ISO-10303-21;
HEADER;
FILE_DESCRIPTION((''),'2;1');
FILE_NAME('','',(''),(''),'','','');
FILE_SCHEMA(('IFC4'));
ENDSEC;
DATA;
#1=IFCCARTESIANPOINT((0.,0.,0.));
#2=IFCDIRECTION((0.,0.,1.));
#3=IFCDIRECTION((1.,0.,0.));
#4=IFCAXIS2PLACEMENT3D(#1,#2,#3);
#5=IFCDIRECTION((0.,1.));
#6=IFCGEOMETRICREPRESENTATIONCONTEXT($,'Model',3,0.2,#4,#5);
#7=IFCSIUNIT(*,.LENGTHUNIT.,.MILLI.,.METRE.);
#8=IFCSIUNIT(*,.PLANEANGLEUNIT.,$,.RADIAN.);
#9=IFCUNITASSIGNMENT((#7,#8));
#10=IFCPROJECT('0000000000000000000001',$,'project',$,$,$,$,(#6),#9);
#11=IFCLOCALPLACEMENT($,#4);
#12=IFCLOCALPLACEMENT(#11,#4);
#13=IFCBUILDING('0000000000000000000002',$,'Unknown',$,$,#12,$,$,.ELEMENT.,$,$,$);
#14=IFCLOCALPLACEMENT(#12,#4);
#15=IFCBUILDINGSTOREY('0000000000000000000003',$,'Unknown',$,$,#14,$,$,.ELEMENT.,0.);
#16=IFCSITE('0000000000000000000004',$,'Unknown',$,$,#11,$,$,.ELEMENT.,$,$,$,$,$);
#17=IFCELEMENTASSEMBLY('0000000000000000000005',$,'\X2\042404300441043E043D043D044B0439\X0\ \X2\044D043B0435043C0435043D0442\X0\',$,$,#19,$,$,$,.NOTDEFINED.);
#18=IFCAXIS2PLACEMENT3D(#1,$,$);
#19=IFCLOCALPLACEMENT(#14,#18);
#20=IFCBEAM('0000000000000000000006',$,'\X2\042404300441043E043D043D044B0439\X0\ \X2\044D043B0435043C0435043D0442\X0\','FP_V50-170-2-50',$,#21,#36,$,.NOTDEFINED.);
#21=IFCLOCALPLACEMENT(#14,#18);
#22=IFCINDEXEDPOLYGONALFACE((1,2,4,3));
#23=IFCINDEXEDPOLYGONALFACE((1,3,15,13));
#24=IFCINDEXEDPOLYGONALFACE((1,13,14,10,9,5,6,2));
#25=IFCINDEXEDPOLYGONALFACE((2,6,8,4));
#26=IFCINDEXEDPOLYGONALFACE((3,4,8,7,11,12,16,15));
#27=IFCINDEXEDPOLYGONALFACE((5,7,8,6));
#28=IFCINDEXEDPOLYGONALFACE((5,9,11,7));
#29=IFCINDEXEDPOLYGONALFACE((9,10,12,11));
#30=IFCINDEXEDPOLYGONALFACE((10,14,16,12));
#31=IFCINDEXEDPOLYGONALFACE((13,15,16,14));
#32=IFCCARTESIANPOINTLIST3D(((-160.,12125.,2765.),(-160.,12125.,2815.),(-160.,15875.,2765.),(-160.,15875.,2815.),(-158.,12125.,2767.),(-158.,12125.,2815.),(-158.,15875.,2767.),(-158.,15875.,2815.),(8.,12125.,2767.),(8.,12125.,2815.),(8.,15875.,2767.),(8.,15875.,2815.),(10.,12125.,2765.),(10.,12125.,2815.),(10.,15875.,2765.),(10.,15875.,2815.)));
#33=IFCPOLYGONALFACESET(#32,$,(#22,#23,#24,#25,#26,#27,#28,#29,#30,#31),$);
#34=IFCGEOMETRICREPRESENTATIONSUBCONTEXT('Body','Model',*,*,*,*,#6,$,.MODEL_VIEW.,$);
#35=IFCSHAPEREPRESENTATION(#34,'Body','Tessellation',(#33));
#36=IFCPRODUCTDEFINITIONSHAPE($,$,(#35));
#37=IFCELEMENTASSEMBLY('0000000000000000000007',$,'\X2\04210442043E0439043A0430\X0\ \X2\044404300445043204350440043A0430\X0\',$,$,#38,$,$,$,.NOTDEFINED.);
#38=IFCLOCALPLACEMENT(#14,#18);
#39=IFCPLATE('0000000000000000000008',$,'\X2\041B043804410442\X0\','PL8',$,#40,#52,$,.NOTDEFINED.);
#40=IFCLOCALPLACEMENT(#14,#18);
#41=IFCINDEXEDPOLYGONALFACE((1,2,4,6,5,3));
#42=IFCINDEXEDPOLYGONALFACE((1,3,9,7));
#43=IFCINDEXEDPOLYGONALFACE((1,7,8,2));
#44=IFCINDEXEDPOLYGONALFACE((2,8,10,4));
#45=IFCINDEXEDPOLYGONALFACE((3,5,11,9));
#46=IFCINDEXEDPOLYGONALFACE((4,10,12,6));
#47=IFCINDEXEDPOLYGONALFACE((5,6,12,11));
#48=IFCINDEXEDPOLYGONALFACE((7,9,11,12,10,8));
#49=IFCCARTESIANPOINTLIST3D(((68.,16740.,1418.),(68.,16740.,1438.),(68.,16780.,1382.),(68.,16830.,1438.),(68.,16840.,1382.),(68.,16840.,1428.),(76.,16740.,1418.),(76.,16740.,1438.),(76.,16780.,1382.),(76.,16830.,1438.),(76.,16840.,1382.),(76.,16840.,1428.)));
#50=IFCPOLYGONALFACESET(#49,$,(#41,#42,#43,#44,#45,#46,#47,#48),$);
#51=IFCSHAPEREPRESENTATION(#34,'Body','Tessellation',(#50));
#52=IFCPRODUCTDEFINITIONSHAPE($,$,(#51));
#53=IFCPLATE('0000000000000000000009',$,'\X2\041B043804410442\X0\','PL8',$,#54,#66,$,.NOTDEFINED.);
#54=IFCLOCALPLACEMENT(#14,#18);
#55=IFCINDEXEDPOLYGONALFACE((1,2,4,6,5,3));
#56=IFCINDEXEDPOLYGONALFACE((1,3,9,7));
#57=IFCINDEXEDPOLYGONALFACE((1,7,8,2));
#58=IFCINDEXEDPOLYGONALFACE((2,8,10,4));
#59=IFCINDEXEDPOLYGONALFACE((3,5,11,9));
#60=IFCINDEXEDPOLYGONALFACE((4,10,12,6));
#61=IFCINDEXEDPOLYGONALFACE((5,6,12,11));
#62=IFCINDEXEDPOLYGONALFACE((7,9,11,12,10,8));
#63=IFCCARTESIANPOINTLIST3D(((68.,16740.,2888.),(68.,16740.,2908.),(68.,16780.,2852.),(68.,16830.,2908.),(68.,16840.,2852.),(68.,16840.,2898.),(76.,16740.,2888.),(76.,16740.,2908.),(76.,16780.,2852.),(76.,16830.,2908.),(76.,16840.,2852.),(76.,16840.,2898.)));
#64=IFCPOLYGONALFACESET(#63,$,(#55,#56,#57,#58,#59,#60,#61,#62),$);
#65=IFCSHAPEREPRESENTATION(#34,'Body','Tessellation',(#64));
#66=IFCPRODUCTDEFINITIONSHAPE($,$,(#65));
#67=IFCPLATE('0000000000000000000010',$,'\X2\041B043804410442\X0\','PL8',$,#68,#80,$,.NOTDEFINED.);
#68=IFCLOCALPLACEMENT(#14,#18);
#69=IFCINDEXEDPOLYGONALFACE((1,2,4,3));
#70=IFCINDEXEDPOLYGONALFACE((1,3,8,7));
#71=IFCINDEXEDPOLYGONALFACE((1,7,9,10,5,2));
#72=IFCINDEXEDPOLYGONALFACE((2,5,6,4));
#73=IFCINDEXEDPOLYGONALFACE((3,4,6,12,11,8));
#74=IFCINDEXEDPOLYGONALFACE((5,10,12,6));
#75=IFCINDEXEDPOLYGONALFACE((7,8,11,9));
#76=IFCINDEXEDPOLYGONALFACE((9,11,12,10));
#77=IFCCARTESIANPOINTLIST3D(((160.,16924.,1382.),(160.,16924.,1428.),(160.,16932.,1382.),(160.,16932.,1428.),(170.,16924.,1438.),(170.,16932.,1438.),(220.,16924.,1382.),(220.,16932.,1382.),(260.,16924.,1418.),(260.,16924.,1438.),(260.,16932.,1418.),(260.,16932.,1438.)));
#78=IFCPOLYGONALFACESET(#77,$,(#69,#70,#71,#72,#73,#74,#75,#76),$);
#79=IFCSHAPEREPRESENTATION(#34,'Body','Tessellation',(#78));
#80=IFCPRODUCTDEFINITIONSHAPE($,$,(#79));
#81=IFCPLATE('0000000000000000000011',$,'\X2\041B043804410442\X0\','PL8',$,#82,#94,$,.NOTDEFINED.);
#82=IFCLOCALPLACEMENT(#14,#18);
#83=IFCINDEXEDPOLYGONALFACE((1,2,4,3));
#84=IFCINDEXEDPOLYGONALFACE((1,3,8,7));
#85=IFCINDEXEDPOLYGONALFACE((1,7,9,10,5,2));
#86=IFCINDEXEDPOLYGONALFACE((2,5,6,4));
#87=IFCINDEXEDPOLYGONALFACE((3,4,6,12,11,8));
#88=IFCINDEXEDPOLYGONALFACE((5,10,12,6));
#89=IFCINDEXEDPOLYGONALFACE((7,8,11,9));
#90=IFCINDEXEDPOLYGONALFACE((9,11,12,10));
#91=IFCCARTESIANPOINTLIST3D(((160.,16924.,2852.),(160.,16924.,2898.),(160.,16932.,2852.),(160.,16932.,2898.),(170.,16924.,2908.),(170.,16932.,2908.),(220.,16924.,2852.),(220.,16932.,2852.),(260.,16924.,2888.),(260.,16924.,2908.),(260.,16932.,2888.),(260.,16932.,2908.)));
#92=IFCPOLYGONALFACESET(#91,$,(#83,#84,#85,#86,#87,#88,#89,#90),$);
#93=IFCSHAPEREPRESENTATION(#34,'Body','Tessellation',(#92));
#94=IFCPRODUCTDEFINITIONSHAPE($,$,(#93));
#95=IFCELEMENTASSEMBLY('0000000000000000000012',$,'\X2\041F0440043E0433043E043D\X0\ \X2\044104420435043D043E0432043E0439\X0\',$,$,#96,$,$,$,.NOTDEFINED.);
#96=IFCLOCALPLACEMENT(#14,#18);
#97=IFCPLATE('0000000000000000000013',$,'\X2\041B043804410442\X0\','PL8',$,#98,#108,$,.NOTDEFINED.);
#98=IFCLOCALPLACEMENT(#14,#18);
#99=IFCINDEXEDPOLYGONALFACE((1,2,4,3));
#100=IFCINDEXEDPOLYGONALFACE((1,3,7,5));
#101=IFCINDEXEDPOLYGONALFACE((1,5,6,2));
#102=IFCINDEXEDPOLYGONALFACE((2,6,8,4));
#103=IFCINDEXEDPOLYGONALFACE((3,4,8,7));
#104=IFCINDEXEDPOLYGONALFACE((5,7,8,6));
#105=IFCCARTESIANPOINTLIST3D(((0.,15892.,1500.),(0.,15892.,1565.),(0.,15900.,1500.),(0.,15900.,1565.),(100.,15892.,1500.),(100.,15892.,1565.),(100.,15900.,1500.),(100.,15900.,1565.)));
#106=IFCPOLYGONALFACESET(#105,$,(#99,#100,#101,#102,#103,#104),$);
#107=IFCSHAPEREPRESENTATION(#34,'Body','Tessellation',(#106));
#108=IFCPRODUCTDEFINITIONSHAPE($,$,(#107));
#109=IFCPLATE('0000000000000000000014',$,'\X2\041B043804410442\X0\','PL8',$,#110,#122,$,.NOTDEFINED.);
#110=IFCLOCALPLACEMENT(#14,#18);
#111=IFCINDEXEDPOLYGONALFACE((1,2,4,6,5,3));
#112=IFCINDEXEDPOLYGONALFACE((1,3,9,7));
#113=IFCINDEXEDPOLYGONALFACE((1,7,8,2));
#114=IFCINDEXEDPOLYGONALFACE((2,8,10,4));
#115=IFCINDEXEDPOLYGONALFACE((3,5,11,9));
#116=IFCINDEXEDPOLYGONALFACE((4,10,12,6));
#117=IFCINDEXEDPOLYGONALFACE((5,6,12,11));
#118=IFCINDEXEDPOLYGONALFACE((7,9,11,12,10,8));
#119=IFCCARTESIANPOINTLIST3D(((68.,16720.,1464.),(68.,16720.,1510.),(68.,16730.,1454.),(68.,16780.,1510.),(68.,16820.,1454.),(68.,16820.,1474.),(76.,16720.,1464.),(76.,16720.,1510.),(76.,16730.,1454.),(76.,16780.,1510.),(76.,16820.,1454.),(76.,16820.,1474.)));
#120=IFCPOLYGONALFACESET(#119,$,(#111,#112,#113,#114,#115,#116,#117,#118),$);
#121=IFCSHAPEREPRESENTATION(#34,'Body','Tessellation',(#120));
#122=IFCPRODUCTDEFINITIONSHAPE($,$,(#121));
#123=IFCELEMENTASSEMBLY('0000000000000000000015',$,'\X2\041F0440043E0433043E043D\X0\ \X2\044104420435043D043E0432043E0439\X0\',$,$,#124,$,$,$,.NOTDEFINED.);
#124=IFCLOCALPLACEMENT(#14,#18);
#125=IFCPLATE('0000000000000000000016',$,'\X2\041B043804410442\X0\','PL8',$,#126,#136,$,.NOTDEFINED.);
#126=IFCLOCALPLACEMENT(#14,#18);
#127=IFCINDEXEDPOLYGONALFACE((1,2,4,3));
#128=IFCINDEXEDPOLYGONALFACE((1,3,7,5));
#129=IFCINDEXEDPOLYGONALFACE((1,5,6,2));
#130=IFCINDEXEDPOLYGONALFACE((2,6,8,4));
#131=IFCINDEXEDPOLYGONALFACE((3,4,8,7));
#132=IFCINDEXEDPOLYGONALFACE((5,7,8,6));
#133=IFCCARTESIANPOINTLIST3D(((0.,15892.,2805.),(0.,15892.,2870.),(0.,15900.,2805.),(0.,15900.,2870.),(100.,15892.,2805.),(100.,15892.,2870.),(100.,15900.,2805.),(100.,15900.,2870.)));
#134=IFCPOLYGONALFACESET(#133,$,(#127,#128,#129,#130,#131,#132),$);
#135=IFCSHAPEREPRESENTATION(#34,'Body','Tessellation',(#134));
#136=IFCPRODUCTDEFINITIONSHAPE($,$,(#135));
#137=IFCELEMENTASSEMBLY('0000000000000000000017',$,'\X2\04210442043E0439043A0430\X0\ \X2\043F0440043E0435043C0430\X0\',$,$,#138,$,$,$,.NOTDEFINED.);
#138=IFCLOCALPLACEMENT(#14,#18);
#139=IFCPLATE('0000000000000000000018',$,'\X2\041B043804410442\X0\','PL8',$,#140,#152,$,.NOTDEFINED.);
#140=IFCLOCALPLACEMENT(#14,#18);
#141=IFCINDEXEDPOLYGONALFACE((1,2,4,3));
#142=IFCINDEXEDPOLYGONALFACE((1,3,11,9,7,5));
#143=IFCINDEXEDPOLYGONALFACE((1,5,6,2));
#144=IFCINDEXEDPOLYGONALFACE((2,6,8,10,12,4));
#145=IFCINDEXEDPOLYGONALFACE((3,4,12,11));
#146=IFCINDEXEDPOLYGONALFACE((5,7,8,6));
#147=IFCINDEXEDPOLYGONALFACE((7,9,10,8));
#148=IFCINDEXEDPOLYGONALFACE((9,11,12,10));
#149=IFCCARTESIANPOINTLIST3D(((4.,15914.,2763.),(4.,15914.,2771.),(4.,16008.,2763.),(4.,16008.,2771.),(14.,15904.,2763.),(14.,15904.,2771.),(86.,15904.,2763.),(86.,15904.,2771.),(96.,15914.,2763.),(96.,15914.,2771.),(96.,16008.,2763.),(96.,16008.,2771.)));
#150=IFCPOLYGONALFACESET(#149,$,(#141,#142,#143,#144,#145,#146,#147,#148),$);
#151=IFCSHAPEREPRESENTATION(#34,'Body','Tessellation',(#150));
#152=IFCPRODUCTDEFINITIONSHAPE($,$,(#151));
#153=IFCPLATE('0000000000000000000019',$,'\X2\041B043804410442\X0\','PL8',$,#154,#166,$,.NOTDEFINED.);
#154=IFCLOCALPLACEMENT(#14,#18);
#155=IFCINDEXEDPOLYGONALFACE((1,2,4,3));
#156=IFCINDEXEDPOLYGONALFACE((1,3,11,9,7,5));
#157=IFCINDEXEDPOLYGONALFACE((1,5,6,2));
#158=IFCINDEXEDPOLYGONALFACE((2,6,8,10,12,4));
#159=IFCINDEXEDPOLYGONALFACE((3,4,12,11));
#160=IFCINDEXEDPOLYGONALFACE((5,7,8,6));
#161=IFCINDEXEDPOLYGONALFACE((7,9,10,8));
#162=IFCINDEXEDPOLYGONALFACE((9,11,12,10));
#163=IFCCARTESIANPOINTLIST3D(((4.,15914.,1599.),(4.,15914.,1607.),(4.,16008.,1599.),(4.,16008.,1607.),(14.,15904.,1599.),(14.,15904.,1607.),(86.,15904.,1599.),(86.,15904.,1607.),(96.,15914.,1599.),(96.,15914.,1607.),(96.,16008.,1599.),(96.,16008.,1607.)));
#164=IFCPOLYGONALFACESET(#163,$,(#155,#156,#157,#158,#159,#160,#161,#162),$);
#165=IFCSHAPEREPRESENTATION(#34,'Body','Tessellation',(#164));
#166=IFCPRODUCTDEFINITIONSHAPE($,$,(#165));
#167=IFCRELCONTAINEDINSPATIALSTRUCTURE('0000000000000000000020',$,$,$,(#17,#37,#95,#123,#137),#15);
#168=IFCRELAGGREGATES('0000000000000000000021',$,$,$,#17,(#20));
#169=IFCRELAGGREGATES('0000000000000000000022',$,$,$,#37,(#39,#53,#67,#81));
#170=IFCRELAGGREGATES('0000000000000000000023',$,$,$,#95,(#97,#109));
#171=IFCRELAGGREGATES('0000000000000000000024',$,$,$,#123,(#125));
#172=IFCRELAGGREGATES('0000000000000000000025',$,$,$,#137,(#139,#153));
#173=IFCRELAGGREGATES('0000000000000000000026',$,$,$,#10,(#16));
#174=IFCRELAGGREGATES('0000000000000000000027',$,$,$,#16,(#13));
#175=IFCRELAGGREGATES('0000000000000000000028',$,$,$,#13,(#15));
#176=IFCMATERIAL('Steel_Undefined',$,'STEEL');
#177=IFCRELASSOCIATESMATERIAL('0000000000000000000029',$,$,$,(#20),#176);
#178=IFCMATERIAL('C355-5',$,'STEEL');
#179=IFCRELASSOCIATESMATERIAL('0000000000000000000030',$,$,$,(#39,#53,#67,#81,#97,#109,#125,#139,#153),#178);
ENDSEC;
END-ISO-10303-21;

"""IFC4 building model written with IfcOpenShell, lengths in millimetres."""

from ifc_helpers import new_model, si_unit, direction, frame, origin_with_axes, place, context, subcontext, project, spatial, line, indexed_curve, outline, extrude, material, element, aggregate, save


model = new_model("IFC4")

# Units and contexts
model_context = context("Model", 3, precision=0.2, world=origin_with_axes(), true_north=direction((0.0, 1.0)))
body_context = subcontext(model_context, "Body", "Model", "MODEL_VIEW")
ifc_project = project(units=[si_unit("LENGTHUNIT", "METRE", prefix="MILLI"), si_unit("PLANEANGLEUNIT", "RADIAN")], contexts=[model_context])

# Site, building, storey
site_placement = place(None, origin_with_axes())
site = spatial("IfcSite", under=ifc_project, at=site_placement, Name="Unknown", CompositionType="ELEMENT")
building_placement = place(site_placement, origin_with_axes())
building = spatial("IfcBuilding", under=site, at=building_placement, Name="Unknown", CompositionType="ELEMENT")
storey_placement = place(building_placement, origin_with_axes())
storey = spatial("IfcBuildingStorey", under=building, at=storey_placement, Name="Unknown", CompositionType="ELEMENT", Elevation=0.0)

# Element assembly, beam
ifc_material_1 = material(Name="Steel_Undefined", Category="STEEL")
assembly_1_placement = place(storey_placement, frame((-75.0, 15875.0, 2790.0), z_axis=(1.0, 0.0, 0.0), x_axis=(0.0, -1.0, 0.0)))
assembly_1 = element("IfcElementAssembly", 1, at=assembly_1_placement, inside=storey, Name="Фасонный элемент", PredefinedType="NOTDEFINED")
beam_1_placement = place(assembly_1_placement, origin_with_axes())
beam_1 = element("IfcBeam", 2, at=beam_1_placement, material=ifc_material_1, Name="Фасонный элемент", Description="FP_V50-170-2-50", PredefinedType="NOTDEFINED", context=body_context, shape_type="SolidModel", body=[
    extrude(outline(indexed_curve([(-85.0, -25.0), (-83.0, -25.0), (-83.0, 23.0), (83.0, 23.0), (83.0, -25.0), (85.0, -25.0), (85.0, 25.0), (-85.0, 25.0)], segments=[line(1, 2, 3, 4, 5, 6, 7, 8, 1)])), frame((0.0, 0.0, 0.0), z_axis=(-1.0, 0.0, 0.0), x_axis=(0.0, 0.0, 1.0)), (0.0, 0.0, -1.0), 3750.0),
])
aggregate(assembly_1, [beam_1])

# Element assemblies, plates
assembly_2_placement = place(storey_placement, frame((80.0, 16920.0, -200.0), z_axis=(0.0, -1.0, 0.0), x_axis=(0.0, 0.0, 1.0)))
assembly_2 = element("IfcElementAssembly", 3, at=assembly_2_placement, inside=storey, Name="Стойка фахверка", PredefinedType="NOTDEFINED")
ifc_material_2 = material(Name="C355-5", Category="STEEL")
plate_1_placement = place(assembly_2_placement, frame((1638.0, 8.0, 90.0), z_axis=(0.0, -1.0, 0.0), x_axis=(0.0, 0.0, 1.0)))
plate_1 = element("IfcPlate", 4, at=plate_1_placement, material=ifc_material_2, Name="Лист", Description="PL8", PredefinedType="NOTDEFINED", context=body_context, shape_type="SolidModel", body=[
    extrude(outline(indexed_curve([(0.0, 0.0), (90.0, 0.0), (90.0, 20.0), (50.0, 56.0), (-10.0, 56.0), (-10.0, 10.0)], segments=[line(1, 2, 3, 4, 5, 6, 1)])), frame((0.0, 0.0, 4.0), z_axis=(0.0, 0.0, 1.0), x_axis=(1.0, 0.0, 0.0)), (0.0, 0.0, -1.0), 8.0),
])
plate_2_placement = place(assembly_2_placement, frame((3108.0, 8.0, 90.0), z_axis=(0.0, -1.0, 0.0), x_axis=(0.0, 0.0, 1.0)))
plate_2 = element("IfcPlate", 5, at=plate_2_placement, material=ifc_material_2, Name="Лист", Description="PL8", PredefinedType="NOTDEFINED", context=body_context, shape_type="SolidModel", body=[
    extrude(outline(indexed_curve([(0.0, 0.0), (90.0, 0.0), (90.0, 20.0), (50.0, 56.0), (-10.0, 56.0), (-10.0, 10.0)], segments=[line(1, 2, 3, 4, 5, 6, 1)])), frame((0.0, 0.0, 4.0), z_axis=(0.0, 0.0, 1.0), x_axis=(1.0, 0.0, 0.0)), (0.0, 0.0, -1.0), 8.0),
])
plate_3_placement = place(assembly_2_placement, frame((1638.0, -90.0, -8.0), z_axis=(0.0, 0.0, -1.0), x_axis=(0.0, -1.0, 0.0)))
plate_3 = element("IfcPlate", 6, at=plate_3_placement, material=ifc_material_2, Name="Лист", Description="PL8", PredefinedType="NOTDEFINED", context=body_context, shape_type="SolidModel", body=[
    extrude(outline(indexed_curve([(0.0, 0.0), (90.0, 0.0), (90.0, 20.0), (50.0, 56.0), (-10.0, 56.0), (-10.0, 10.0)], segments=[line(1, 2, 3, 4, 5, 6, 1)])), frame((0.0, 0.0, 4.0), z_axis=(0.0, 0.0, 1.0), x_axis=(1.0, 0.0, 0.0)), (0.0, 0.0, -1.0), 8.0),
])
plate_4_placement = place(assembly_2_placement, frame((3108.0, -90.0, -8.0), z_axis=(0.0, 0.0, -1.0), x_axis=(0.0, -1.0, 0.0)))
plate_4 = element("IfcPlate", 7, at=plate_4_placement, material=ifc_material_2, Name="Лист", Description="PL8", PredefinedType="NOTDEFINED", context=body_context, shape_type="SolidModel", body=[
    extrude(outline(indexed_curve([(0.0, 0.0), (90.0, 0.0), (90.0, 20.0), (50.0, 56.0), (-10.0, 56.0), (-10.0, 10.0)], segments=[line(1, 2, 3, 4, 5, 6, 1)])), frame((0.0, 0.0, 4.0), z_axis=(0.0, 0.0, 1.0), x_axis=(1.0, 0.0, 0.0)), (0.0, 0.0, -1.0), 8.0),
])
aggregate(assembly_2, [plate_1, plate_2, plate_3, plate_4])
assembly_3_placement = place(storey_placement, frame((50.0, 17000.0, 1450.0), z_axis=(0.0, 0.0, -1.0), x_axis=(0.0, -1.0, 0.0)))
assembly_3 = element("IfcElementAssembly", 8, at=assembly_3_placement, inside=storey, Name="Прогон стеновой", PredefinedType="NOTDEFINED")
plate_5_placement = place(assembly_3_placement, frame((1104.0, 50.0, -50.0), z_axis=(-1.0, 0.0, 0.0), x_axis=(0.0, 0.0, -1.0)))
plate_5 = element("IfcPlate", 9, at=plate_5_placement, material=ifc_material_2, Name="Лист", Description="PL8", PredefinedType="NOTDEFINED", context=body_context, shape_type="SolidModel", body=[
    extrude(outline(indexed_curve([(0.0, 0.0), (65.0, 0.0), (65.0, 100.0), (0.0, 100.0)], segments=[line(1, 2, 3, 4, 1)])), frame((0.0, 0.0, 4.0), z_axis=(0.0, 0.0, 1.0), x_axis=(1.0, 0.0, 0.0)), (0.0, 0.0, -1.0), 8.0),
])
plate_6_placement = place(assembly_3_placement, frame((180.0, -22.0, -60.0), z_axis=(0.0, 1.0, 0.0), x_axis=(0.0, 0.0, 1.0)))
plate_6 = element("IfcPlate", 10, at=plate_6_placement, material=ifc_material_2, Name="Лист", Description="PL8", PredefinedType="NOTDEFINED", context=body_context, shape_type="SolidModel", body=[
    extrude(outline(indexed_curve([(0.0, 40.0), (36.0, 0.0), (56.0, 0.0), (56.0, 90.0), (46.0, 100.0), (0.0, 100.0)], segments=[line(1, 2, 3, 4, 5, 6, 1)])), frame((0.0, 0.0, 4.0), z_axis=(0.0, 0.0, 1.0), x_axis=(1.0, 0.0, 0.0)), (0.0, 0.0, -1.0), 8.0),
])
aggregate(assembly_3, [plate_5, plate_6])
assembly_4_placement = place(storey_placement, frame((50.0, 17000.0, 2920.0), z_axis=(0.0, 0.0, -1.0), x_axis=(0.0, -1.0, 0.0)))
assembly_4 = element("IfcElementAssembly", 11, at=assembly_4_placement, inside=storey, Name="Прогон стеновой", PredefinedType="NOTDEFINED")
plate_7_placement = place(assembly_4_placement, frame((1104.0, -50.0, 50.0), z_axis=(-1.0, 0.0, 0.0), x_axis=(0.0, 0.0, 1.0)))
plate_7 = element("IfcPlate", 12, at=plate_7_placement, material=ifc_material_2, Name="Лист", Description="PL8", PredefinedType="NOTDEFINED", context=body_context, shape_type="SolidModel", body=[
    extrude(outline(indexed_curve([(0.0, 0.0), (65.0, 0.0), (65.0, 100.0), (0.0, 100.0)], segments=[line(1, 2, 3, 4, 1)])), frame((0.0, 0.0, 4.0), z_axis=(0.0, 0.0, 1.0), x_axis=(1.0, 0.0, 0.0)), (0.0, 0.0, -1.0), 8.0),
])
aggregate(assembly_4, [plate_7])
assembly_5_placement = place(storey_placement, frame((50.0, 15950.0, 1500.0), z_axis=(0.0, -1.0, 0.0), x_axis=(0.0, 0.0, 1.0)))
assembly_5 = element("IfcElementAssembly", 13, at=assembly_5_placement, inside=storey, Name="Стойка проема", PredefinedType="NOTDEFINED")
plate_8_placement = place(assembly_5_placement, frame((1267.0, 46.0, 46.0), z_axis=(1.0, 0.0, 0.0), x_axis=(0.0, -1.0, 0.0)))
plate_8 = element("IfcPlate", 14, at=plate_8_placement, material=ifc_material_2, Name="Лист", Description="PL8", PredefinedType="NOTDEFINED", context=body_context, shape_type="SolidModel", body=[
    extrude(outline(indexed_curve([(0.0, 10.0), (10.0, 0.0), (82.0, 0.0), (92.0, 10.0), (92.0, 104.0), (0.0, 104.0)], segments=[line(1, 2, 3, 4, 5, 6, 1)])), frame((0.0, 0.0, 4.0), z_axis=(0.0, 0.0, 1.0), x_axis=(1.0, 0.0, 0.0)), (0.0, 0.0, -1.0), 8.0),
])
plate_9_placement = place(assembly_5_placement, frame((103.0, -46.0, 46.0), z_axis=(-1.0, 0.0, 0.0), x_axis=(0.0, 1.0, 0.0)))
plate_9 = element("IfcPlate", 15, at=plate_9_placement, material=ifc_material_2, Name="Лист", Description="PL8", PredefinedType="NOTDEFINED", context=body_context, shape_type="SolidModel", body=[
    extrude(outline(indexed_curve([(0.0, 10.0), (10.0, 0.0), (82.0, 0.0), (92.0, 10.0), (92.0, 104.0), (0.0, 104.0)], segments=[line(1, 2, 3, 4, 5, 6, 1)])), frame((0.0, 0.0, 4.0), z_axis=(0.0, 0.0, 1.0), x_axis=(1.0, 0.0, 0.0)), (0.0, 0.0, -1.0), 8.0),
])
aggregate(assembly_5, [plate_8, plate_9])

save(model, "model.ifc")
